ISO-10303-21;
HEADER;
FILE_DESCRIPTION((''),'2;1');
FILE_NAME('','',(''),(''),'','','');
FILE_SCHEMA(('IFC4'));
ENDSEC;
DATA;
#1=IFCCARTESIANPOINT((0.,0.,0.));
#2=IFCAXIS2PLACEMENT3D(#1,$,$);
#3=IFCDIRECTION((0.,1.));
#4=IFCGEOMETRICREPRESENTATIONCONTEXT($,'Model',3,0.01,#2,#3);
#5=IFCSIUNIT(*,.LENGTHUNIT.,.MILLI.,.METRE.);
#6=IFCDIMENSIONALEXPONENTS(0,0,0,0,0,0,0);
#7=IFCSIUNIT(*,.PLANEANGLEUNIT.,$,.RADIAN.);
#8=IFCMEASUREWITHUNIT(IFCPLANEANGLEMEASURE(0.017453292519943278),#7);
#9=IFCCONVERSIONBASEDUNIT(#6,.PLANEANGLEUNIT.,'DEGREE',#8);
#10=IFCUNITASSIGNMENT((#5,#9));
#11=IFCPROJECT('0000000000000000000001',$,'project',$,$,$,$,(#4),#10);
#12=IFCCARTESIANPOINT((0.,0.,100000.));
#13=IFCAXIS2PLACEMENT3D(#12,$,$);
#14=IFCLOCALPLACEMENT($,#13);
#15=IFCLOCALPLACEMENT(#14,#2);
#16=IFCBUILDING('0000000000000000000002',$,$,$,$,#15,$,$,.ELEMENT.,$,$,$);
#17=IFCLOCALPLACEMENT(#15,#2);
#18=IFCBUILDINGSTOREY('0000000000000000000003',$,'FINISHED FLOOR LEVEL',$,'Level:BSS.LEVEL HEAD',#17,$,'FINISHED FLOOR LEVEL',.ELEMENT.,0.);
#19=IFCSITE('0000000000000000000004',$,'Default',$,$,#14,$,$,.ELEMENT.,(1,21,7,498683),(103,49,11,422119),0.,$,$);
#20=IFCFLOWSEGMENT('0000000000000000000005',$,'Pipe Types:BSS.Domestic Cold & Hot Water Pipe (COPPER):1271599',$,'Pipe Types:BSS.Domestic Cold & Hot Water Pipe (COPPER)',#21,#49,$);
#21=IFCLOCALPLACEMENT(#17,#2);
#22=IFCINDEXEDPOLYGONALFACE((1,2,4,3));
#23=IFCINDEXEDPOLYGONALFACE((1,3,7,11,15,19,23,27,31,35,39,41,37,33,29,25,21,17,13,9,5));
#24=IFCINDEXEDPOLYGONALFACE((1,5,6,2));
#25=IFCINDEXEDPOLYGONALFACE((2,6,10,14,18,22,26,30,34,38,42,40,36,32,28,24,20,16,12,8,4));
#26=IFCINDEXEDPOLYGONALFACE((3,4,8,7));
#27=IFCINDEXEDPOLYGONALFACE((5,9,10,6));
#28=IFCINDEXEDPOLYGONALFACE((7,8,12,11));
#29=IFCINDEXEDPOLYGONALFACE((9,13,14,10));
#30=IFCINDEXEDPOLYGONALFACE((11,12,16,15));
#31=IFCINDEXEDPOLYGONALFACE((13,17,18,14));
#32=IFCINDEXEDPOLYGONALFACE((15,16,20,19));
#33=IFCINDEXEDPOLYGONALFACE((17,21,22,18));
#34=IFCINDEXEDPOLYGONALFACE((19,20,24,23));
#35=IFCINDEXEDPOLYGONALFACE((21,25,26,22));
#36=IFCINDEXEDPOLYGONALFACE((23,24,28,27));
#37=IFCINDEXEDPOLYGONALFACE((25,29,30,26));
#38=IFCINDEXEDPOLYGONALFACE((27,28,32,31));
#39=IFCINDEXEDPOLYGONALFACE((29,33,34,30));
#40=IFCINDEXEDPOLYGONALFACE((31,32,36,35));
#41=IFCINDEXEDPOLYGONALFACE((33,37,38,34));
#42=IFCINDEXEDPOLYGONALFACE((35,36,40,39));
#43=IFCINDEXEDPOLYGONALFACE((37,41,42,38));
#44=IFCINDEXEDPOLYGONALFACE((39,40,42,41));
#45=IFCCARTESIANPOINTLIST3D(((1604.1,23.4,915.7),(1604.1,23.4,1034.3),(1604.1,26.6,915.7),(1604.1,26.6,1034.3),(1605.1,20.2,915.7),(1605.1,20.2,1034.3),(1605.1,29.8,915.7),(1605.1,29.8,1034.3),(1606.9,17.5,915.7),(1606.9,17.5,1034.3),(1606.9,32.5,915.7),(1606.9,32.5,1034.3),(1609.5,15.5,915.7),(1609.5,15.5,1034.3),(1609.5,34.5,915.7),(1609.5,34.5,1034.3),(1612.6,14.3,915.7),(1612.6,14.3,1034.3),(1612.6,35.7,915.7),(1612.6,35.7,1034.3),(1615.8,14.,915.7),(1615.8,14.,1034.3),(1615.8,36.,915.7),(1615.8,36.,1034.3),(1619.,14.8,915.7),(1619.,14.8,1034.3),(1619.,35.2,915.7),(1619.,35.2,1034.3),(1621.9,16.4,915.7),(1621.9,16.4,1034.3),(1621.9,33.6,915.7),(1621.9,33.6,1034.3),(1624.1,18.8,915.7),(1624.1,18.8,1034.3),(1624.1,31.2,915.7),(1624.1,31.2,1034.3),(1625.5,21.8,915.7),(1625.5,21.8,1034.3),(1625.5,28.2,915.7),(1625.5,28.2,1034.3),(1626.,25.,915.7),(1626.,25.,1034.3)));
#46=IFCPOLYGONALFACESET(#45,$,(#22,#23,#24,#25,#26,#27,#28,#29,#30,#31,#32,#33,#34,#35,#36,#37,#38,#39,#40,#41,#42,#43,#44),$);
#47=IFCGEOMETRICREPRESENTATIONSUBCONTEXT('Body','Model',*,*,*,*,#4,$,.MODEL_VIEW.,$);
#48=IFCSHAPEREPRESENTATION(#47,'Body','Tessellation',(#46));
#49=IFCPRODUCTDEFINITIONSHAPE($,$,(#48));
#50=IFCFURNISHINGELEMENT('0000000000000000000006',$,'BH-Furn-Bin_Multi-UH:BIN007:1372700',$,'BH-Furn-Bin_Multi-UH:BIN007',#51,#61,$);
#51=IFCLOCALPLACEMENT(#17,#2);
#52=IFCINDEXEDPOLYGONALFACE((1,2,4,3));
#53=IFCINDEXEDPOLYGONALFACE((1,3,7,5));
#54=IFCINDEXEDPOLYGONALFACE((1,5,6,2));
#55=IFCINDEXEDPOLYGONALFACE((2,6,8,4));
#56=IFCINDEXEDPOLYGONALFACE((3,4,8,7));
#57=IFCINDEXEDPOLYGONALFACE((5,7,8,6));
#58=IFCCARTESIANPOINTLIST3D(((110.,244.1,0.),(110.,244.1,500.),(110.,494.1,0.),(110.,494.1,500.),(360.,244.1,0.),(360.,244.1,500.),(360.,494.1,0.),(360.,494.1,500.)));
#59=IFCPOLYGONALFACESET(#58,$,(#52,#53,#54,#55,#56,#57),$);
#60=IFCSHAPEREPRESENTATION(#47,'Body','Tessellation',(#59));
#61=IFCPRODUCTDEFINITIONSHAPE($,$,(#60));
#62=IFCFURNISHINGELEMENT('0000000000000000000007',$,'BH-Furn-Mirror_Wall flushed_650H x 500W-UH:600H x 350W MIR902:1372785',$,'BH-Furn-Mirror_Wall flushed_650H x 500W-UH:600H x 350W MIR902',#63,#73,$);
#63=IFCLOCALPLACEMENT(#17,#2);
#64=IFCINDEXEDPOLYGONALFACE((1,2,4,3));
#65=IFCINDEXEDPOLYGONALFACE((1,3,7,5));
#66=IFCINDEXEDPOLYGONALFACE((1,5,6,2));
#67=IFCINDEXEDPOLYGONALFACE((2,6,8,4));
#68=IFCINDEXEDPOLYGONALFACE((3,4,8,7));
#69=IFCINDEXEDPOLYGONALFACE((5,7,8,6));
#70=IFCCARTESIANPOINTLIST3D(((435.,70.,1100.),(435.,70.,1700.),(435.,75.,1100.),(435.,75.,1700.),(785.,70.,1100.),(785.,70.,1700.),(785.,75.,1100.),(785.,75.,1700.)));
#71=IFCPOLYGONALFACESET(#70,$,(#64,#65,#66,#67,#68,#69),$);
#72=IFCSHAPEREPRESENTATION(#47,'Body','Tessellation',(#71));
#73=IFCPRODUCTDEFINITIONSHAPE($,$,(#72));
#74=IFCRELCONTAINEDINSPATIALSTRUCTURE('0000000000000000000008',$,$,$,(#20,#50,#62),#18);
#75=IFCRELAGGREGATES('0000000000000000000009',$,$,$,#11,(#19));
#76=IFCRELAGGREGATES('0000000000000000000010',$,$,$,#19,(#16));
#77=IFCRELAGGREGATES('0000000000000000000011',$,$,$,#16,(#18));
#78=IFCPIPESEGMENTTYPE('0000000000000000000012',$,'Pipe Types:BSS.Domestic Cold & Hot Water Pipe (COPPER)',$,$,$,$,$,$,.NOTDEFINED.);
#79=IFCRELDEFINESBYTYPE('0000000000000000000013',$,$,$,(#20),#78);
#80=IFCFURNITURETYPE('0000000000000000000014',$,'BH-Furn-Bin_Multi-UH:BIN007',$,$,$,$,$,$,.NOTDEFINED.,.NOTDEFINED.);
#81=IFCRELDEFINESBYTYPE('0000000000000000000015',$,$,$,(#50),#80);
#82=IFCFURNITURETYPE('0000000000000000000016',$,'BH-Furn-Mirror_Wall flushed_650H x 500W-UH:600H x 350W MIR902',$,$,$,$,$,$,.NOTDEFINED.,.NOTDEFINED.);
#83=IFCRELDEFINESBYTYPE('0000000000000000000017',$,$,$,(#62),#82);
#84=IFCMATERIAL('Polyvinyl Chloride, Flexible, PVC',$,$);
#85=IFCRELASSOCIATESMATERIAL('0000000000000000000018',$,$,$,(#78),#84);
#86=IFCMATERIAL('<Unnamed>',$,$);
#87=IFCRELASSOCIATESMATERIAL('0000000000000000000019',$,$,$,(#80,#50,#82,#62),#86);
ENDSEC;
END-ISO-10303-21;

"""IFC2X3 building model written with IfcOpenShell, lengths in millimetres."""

from ifc_helpers import new_model, entity, si_unit, converted_unit, direction, frame, frame_2d, origin, origin_2d_with_axis, place, context, subcontext, project, spatial, rectangle, circle, extrude, source, transform, mapped, material, type_object, type_shapes, element, save


model = new_model("IFC2X3")

# Units and contexts
model_context = context("Model", 3, precision=0.01, world=origin(), true_north=direction((0.0, 1.0)))
body_context = subcontext(model_context, "Body", "Model", "MODEL_VIEW")
ifc_project = project(units=[si_unit("LENGTHUNIT", "METRE", prefix="MILLI"), converted_unit("PLANEANGLEUNIT", "DEGREE", entity("IfcPlaneAngleMeasure", 0.017453292519943278), si_unit("PLANEANGLEUNIT", "RADIAN"), dimensions=[0, 0, 0, 0, 0, 0, 0])], contexts=[model_context])

# Site, building, storey
site_placement = place(None, frame((0.0, 0.0, 100000.0)))
site = spatial("IfcSite", under=ifc_project, at=site_placement, Name="Default", CompositionType="ELEMENT", RefLatitude=(1, 21, 7, 498683), RefLongitude=(103, 49, 11, 422119), RefElevation=0.0)
building_placement = place(site_placement, origin())
building = spatial("IfcBuilding", under=site, at=building_placement, CompositionType="ELEMENT")
storey_placement = place(building_placement, origin())
storey = spatial("IfcBuildingStorey", under=building, at=storey_placement, Name="FINISHED FLOOR LEVEL", ObjectType="Level:BSS.LEVEL HEAD", LongName="FINISHED FLOOR LEVEL", CompositionType="ELEMENT", Elevation=0.0)

# Flow segment
ifc_material_1 = material(Name="Polyvinyl Chloride, Flexible, PVC")
pipe_segment_type_1 = type_object("IfcPipeSegmentType", Name="Pipe Types:BSS.Domestic Cold & Hot Water Pipe (COPPER)", PredefinedType="NOTDEFINED", material=ifc_material_1)
flow_segment_1_placement = place(storey_placement, origin())
element("IfcFlowSegment", 1, at=flow_segment_1_placement, inside=storey, type_object=pipe_segment_type_1, Name="Pipe Types:BSS.Domestic Cold & Hot Water Pipe (COPPER):1271599", ObjectType="Pipe Types:BSS.Domestic Cold & Hot Water Pipe (COPPER)", context=body_context, shape_type="SweptSolid", body=[
    extrude(circle(Radius=11.0, at=frame_2d((0.0, 0.0), x_axis=(1.0, 0.0))), frame((1615.0, 25.0, 915.7)), (0.0, 0.0, 1.0), 118.7),
])

# Furnishing elements
ifc_material_2 = material(Name="<Unnamed>")
furniture_type_1 = type_object("IfcFurnitureType", Name="BH-Furn-Bin_Multi-UH:BIN007", AssemblyPlace="NOTDEFINED", material=ifc_material_2)
shared_shape_1 = source(origin(), body_context, "Body", "SweptSolid", [
    extrude(rectangle(XDim=250.0, YDim=250.0, at=origin_2d_with_axis()), frame((0.0, 0.0, 0.0), z_axis=(0.0, 0.0, 1.0), x_axis=(-1.0, 0.0, 0.0)), (0.0, 0.0, 1.0), 500.0),
])
type_shapes(furniture_type_1, [shared_shape_1])
furnishing_1_placement = place(storey_placement, frame((235.0, 369.1, 0.0), z_axis=(0.0, 0.0, 1.0), x_axis=(0.0, 1.0, 0.0)))
element("IfcFurnishingElement", 2, at=furnishing_1_placement, inside=storey, type_object=furniture_type_1, material=ifc_material_2, Name="BH-Furn-Bin_Multi-UH:BIN007:1372700", ObjectType="BH-Furn-Bin_Multi-UH:BIN007", context=body_context, shape_type="MappedRepresentation", body=[
    mapped(shared_shape_1, transform((0.0, 0.0, 0.0), scale=1.0)),
])
furniture_type_2 = type_object("IfcFurnitureType", Name="BH-Furn-Mirror_Wall flushed_650H x 500W-UH:600H x 350W MIR902", AssemblyPlace="NOTDEFINED", material=ifc_material_2)
shared_shape_2 = source(origin(), body_context, "Body", "SweptSolid", [
    extrude(rectangle(XDim=5.0, YDim=350.0, at=origin_2d_with_axis()), frame((0.0, -2.5, 1300.0), z_axis=(0.0, 0.0, 1.0), x_axis=(0.0, 1.0, 0.0)), (0.0, 0.0, 1.0), 600.0),
])
type_shapes(furniture_type_2, [shared_shape_2])
furnishing_2_placement = place(storey_placement, frame((610.0, 75.0, -200.0)))
element("IfcFurnishingElement", 3, at=furnishing_2_placement, inside=storey, type_object=furniture_type_2, material=ifc_material_2, Name="BH-Furn-Mirror_Wall flushed_650H x 500W-UH:600H x 350W MIR902:1372785", ObjectType="BH-Furn-Mirror_Wall flushed_650H x 500W-UH:600H x 350W MIR902", context=body_context, shape_type="MappedRepresentation", body=[
    mapped(shared_shape_2, transform((0.0, 0.0, 0.0), scale=1.0)),
])

save(model, "model.ifc")
